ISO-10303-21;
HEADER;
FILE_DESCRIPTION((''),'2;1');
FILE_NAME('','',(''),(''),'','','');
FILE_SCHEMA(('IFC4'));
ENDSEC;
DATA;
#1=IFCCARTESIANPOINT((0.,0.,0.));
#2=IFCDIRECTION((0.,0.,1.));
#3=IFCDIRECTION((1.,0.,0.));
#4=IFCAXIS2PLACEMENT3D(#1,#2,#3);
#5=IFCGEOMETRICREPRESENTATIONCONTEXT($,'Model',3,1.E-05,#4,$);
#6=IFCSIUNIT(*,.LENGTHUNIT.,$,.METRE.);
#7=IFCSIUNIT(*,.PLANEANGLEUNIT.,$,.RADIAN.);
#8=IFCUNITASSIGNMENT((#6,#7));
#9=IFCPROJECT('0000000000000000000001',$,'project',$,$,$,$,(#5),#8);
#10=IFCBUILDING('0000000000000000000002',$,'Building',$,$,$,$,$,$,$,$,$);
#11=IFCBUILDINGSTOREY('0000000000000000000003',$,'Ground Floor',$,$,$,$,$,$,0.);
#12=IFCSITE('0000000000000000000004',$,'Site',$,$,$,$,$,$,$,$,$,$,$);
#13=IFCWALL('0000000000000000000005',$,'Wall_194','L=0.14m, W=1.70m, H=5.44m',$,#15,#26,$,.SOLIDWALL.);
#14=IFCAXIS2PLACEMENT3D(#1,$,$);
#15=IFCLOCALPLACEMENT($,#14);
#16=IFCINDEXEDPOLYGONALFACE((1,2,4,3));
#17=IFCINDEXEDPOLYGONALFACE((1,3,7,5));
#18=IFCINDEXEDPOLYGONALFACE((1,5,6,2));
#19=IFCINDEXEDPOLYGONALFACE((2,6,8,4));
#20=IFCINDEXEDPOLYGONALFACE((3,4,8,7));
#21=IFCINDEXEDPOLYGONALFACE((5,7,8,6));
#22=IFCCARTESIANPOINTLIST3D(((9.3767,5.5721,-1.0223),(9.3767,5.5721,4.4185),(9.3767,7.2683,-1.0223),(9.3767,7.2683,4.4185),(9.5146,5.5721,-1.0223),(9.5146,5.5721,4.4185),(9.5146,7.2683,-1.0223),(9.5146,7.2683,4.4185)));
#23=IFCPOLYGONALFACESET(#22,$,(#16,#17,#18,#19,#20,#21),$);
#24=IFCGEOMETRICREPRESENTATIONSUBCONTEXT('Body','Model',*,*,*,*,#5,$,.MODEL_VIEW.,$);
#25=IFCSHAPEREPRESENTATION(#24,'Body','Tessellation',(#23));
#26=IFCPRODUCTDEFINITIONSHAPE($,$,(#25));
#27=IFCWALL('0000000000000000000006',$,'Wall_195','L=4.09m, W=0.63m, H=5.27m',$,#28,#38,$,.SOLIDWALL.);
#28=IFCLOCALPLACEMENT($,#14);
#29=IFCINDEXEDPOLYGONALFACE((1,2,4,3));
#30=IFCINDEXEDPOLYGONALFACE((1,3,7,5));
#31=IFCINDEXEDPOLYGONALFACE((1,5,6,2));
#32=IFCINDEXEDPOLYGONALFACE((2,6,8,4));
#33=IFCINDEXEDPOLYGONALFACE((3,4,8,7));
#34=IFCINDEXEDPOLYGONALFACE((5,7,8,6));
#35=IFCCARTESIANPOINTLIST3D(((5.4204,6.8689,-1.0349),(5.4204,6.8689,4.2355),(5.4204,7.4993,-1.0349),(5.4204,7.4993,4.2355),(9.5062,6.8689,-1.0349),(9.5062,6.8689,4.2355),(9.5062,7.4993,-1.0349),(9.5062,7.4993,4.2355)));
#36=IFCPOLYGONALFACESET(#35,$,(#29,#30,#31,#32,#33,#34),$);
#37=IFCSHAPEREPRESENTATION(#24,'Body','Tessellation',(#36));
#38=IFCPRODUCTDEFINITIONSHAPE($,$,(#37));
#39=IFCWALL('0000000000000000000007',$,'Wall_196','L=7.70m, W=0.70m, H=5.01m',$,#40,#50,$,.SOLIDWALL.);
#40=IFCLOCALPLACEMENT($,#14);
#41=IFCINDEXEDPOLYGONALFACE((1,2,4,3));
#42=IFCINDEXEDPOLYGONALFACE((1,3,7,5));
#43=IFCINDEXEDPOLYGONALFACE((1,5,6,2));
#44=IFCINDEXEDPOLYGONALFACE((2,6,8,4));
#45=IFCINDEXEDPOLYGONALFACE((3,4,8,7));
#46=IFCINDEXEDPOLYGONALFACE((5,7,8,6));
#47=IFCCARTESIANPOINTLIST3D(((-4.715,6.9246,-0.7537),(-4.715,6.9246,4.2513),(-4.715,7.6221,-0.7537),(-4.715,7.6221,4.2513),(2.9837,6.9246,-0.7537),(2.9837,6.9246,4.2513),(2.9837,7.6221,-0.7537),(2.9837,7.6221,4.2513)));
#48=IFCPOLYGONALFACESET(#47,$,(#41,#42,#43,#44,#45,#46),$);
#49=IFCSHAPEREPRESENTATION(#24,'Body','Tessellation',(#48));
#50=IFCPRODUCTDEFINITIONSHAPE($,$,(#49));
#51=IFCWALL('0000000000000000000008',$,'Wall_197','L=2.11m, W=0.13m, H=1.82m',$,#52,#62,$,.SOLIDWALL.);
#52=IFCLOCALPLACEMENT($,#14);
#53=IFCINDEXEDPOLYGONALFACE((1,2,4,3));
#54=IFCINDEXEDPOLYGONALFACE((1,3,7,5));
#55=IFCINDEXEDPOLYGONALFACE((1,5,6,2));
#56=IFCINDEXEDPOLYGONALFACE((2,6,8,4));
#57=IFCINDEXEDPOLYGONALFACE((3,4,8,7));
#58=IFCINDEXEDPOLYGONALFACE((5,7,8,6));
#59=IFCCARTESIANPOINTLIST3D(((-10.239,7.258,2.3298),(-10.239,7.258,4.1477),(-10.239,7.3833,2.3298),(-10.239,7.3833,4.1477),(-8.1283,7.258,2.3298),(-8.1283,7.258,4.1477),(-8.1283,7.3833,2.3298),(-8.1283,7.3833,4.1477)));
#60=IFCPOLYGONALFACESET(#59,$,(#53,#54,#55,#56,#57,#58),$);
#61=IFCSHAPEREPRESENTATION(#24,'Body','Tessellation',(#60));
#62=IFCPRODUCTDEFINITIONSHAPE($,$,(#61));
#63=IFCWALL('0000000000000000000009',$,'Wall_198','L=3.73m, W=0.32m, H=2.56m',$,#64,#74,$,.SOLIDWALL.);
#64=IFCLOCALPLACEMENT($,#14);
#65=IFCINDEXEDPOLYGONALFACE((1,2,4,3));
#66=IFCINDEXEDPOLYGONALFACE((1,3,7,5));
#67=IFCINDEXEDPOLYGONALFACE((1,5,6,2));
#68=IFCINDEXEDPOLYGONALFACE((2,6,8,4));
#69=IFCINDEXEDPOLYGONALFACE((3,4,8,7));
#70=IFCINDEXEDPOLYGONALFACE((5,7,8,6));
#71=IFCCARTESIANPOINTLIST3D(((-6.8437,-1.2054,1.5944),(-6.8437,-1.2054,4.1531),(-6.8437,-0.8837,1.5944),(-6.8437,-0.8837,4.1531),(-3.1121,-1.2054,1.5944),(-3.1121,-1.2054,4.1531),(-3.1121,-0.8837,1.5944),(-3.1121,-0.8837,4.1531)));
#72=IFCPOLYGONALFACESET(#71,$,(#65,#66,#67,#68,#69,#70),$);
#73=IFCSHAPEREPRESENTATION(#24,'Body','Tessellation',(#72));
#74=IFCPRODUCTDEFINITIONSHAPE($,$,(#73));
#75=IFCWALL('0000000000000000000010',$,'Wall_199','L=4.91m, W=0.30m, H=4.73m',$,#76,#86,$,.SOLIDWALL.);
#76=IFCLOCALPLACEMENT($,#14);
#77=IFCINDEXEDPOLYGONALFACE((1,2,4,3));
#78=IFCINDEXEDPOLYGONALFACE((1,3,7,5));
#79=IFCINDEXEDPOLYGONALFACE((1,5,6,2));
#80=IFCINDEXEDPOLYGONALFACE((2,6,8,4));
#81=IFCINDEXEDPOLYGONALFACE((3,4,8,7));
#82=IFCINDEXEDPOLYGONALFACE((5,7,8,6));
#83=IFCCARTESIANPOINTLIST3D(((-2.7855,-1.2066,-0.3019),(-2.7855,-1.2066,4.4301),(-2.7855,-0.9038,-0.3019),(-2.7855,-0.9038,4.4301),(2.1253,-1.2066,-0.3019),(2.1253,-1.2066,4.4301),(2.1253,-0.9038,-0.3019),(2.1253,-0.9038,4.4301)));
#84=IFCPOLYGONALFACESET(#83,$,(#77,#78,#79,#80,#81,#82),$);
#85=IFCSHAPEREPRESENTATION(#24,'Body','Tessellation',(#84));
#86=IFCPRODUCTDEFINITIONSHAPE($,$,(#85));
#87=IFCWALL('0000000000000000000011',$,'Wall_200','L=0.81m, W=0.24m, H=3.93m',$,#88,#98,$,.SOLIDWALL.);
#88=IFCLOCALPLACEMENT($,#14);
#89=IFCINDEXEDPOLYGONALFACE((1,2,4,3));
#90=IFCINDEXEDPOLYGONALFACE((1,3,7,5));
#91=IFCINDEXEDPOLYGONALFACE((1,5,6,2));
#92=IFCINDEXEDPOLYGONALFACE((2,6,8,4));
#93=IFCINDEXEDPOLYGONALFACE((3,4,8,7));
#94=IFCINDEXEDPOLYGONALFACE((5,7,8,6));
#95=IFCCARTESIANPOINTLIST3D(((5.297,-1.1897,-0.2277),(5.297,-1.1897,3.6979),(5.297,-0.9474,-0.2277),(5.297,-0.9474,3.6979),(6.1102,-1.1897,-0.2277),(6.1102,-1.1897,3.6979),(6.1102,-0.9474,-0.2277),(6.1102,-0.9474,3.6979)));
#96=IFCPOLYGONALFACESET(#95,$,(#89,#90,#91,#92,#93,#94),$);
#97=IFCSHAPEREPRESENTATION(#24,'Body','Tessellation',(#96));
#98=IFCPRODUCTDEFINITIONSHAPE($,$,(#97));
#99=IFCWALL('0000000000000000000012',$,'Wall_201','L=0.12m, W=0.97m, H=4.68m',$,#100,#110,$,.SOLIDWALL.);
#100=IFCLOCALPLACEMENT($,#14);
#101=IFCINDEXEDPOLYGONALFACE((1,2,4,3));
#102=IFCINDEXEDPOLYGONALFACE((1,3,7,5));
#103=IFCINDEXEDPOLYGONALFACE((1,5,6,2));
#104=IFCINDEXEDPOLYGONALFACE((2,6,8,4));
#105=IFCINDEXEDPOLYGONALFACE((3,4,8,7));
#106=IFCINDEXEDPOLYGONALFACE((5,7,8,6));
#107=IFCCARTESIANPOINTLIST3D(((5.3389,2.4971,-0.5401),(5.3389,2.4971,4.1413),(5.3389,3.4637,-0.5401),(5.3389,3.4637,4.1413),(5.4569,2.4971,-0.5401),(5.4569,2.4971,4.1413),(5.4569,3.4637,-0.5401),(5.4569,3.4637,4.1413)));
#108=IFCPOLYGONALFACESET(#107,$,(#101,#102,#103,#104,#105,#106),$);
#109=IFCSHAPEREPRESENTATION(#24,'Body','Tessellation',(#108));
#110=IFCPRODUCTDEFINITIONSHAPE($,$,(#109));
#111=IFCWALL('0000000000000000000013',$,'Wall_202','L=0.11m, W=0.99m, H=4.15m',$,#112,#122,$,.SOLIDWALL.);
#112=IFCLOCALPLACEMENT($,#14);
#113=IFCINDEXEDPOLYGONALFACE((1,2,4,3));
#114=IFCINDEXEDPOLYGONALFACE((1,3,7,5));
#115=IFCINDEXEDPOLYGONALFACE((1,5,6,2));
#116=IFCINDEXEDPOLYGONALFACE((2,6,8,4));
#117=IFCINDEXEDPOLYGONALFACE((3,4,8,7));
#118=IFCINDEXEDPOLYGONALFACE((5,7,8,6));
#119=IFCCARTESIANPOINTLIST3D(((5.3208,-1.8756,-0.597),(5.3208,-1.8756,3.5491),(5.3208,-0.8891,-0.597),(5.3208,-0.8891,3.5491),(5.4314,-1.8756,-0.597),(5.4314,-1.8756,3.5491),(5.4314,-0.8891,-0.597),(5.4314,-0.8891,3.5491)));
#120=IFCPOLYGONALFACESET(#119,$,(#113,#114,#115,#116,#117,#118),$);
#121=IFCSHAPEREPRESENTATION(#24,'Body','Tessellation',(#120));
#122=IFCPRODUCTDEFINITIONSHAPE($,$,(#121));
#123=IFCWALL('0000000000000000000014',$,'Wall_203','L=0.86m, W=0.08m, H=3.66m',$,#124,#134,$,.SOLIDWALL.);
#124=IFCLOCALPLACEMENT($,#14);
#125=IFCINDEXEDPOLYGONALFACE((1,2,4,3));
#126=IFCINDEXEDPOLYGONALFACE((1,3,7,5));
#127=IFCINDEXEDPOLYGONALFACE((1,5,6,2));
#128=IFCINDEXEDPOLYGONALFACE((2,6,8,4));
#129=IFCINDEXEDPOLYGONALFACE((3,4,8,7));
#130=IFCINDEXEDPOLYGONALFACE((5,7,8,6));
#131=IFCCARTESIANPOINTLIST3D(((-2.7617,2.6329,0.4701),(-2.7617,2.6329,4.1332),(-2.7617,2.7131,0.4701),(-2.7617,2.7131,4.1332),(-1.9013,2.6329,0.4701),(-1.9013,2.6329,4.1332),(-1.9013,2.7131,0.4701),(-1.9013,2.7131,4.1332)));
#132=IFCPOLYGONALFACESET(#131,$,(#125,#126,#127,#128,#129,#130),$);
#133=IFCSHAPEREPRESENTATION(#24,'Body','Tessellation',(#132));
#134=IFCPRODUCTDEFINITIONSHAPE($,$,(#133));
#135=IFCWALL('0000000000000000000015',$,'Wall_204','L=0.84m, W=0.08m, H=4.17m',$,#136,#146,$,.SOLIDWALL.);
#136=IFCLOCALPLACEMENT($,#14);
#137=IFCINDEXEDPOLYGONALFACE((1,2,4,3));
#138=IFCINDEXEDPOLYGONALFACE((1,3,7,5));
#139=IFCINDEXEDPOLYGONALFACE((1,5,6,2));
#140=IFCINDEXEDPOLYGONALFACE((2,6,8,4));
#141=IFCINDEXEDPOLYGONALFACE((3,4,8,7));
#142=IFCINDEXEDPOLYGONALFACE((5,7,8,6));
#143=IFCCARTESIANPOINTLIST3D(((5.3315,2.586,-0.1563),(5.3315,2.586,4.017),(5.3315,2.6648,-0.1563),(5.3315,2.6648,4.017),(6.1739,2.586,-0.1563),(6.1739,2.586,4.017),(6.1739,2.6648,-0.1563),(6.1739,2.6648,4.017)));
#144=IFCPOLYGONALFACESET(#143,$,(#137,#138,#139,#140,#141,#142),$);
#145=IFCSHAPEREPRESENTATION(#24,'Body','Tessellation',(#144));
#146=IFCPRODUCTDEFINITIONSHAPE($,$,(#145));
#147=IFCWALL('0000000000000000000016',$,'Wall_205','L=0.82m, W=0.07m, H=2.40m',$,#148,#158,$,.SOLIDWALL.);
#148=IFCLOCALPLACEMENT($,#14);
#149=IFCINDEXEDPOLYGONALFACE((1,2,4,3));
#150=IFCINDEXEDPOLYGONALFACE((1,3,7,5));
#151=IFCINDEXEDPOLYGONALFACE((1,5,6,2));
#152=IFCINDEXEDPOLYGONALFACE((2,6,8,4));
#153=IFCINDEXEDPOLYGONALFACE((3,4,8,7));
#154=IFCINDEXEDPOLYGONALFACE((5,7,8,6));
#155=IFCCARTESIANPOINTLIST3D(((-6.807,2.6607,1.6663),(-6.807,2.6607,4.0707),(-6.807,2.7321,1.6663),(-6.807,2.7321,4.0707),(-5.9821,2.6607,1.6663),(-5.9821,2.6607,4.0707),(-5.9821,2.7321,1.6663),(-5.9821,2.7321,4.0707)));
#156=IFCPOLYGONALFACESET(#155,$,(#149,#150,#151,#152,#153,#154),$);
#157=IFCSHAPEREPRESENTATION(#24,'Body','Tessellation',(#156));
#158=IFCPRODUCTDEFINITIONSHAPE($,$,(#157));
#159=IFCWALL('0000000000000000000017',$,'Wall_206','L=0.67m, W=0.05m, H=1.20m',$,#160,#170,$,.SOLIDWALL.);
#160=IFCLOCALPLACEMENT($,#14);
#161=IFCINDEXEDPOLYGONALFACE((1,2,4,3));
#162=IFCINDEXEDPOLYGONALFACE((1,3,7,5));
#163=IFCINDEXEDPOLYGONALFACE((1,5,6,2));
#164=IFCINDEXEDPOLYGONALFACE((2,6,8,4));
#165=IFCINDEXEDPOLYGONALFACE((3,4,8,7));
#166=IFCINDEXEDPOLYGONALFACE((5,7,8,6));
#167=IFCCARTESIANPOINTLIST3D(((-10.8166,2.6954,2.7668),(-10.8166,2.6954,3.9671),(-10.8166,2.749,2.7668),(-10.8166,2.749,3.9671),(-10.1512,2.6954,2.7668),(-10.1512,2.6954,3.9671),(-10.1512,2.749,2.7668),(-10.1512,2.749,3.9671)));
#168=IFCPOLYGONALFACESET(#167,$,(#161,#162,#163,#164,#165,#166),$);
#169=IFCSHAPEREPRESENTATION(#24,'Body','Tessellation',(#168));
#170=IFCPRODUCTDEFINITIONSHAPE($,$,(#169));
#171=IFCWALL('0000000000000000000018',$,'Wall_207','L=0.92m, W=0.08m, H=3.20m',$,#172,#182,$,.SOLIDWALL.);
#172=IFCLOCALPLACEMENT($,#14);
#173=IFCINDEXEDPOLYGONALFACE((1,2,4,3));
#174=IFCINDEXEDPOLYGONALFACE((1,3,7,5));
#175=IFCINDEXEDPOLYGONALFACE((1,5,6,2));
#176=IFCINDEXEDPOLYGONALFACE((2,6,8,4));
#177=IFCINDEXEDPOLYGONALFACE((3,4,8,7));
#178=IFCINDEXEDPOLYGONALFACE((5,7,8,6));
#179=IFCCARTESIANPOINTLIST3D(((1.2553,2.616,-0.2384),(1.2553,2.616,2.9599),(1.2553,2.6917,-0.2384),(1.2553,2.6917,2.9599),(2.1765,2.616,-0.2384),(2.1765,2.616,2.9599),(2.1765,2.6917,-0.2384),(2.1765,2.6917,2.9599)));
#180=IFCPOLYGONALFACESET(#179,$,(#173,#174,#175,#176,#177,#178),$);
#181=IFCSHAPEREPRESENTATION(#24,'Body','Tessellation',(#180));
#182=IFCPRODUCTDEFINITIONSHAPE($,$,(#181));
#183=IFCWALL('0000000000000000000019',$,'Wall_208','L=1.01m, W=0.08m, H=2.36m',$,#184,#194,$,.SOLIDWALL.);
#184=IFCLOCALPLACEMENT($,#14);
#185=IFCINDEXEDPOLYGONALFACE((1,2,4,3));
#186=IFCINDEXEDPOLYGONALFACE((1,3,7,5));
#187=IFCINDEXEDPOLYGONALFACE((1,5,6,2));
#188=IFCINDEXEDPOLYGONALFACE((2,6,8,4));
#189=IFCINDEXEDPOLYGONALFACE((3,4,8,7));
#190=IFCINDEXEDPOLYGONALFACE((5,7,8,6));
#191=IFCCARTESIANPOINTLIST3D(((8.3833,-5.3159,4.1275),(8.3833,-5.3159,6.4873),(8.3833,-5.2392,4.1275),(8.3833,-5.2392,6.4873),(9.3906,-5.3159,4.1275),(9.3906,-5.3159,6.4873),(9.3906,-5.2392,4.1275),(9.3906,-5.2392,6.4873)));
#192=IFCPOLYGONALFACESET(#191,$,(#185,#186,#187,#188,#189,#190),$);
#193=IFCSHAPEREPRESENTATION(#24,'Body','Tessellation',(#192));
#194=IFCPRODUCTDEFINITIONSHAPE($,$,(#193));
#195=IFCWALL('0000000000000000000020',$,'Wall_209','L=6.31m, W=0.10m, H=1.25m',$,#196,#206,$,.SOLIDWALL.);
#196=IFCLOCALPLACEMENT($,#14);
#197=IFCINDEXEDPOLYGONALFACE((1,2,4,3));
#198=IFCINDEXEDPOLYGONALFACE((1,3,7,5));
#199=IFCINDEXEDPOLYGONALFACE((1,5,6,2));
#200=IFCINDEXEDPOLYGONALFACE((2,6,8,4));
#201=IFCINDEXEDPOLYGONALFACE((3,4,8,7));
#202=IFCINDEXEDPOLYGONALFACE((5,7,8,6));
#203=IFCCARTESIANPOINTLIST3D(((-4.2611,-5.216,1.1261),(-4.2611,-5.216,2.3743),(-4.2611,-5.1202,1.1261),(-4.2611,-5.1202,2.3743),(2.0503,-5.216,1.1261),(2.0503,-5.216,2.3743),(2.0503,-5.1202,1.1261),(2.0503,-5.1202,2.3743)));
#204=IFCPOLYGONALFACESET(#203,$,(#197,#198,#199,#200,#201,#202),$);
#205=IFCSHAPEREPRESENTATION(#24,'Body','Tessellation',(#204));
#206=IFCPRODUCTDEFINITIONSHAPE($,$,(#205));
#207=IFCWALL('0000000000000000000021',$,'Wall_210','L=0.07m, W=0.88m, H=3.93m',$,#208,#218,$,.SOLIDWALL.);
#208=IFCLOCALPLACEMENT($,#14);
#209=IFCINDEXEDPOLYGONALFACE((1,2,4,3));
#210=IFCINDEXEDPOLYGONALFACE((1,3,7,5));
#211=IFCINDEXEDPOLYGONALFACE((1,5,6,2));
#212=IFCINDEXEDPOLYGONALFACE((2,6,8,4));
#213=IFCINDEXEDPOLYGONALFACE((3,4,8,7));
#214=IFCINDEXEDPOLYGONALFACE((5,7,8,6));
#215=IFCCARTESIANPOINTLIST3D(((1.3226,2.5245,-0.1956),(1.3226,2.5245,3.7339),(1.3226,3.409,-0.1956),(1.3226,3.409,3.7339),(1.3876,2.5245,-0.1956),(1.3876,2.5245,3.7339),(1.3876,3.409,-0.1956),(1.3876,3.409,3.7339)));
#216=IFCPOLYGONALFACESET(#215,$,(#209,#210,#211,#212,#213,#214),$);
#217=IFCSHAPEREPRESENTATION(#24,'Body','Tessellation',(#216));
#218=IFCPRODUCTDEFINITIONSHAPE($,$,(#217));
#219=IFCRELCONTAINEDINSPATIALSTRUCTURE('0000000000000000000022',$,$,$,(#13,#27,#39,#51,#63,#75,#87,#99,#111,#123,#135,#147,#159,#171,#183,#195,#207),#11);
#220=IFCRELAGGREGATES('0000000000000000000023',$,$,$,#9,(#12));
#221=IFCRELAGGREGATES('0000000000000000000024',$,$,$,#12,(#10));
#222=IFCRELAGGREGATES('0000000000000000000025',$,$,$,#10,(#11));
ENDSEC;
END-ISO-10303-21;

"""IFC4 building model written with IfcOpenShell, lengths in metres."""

from ifc_helpers import new_model, si_unit, frame, origin_with_axes, origin_2d, context, subcontext, project, spatial, rectangle, extrude, element, save


model = new_model("IFC4")

# Units and contexts
model_context = context("Model", 3, precision=1e-05, world=origin_with_axes())
body_context = subcontext(model_context, "Body", "Model", "MODEL_VIEW")
ifc_project = project(units=[si_unit("LENGTHUNIT", "METRE"), si_unit("PLANEANGLEUNIT", "RADIAN")], contexts=[model_context])

# Site, building, storey
site = spatial("IfcSite", under=ifc_project, Name="Site")
building = spatial("IfcBuilding", under=site, Name="Building")
storey = spatial("IfcBuildingStorey", under=building, Name="Ground Floor", Elevation=0.0)

# Walls
element("IfcWall", 1, inside=storey, Name="Wall_194", Description="L=0.14m, W=1.70m, H=5.44m", PredefinedType="SOLIDWALL", context=body_context, shape_type="SweptSolid", body=[
    extrude(rectangle(XDim=0.1379, YDim=1.6961, at=origin_2d()), frame((9.4457, 6.4202, -1.0223), z_axis=(0.0, 0.0, 1.0), x_axis=(1.0, 0.0, 0.0)), (0.0, 0.0, 1.0), 5.4408),
])
element("IfcWall", 2, inside=storey, Name="Wall_195", Description="L=4.09m, W=0.63m, H=5.27m", PredefinedType="SOLIDWALL", context=body_context, shape_type="SweptSolid", body=[
    extrude(rectangle(XDim=4.0858, YDim=0.6304, at=origin_2d()), frame((7.4633, 7.1841, -1.0349), z_axis=(0.0, 0.0, 1.0), x_axis=(1.0, 0.0, 0.0)), (0.0, 0.0, 1.0), 5.2704),
])
element("IfcWall", 3, inside=storey, Name="Wall_196", Description="L=7.70m, W=0.70m, H=5.01m", PredefinedType="SOLIDWALL", context=body_context, shape_type="SweptSolid", body=[
    extrude(rectangle(XDim=7.6987, YDim=0.6975, at=origin_2d()), frame((-0.8657, 7.2734, -0.7537), z_axis=(0.0, 0.0, 1.0), x_axis=(1.0, 0.0, 0.0)), (0.0, 0.0, 1.0), 5.005),
])
element("IfcWall", 4, inside=storey, Name="Wall_197", Description="L=2.11m, W=0.13m, H=1.82m", PredefinedType="SOLIDWALL", context=body_context, shape_type="SweptSolid", body=[
    extrude(rectangle(XDim=2.1107, YDim=0.1253, at=origin_2d()), frame((-9.1836, 7.3206, 2.3298), z_axis=(0.0, 0.0, 1.0), x_axis=(1.0, 0.0, 0.0)), (0.0, 0.0, 1.0), 1.8179),
])
element("IfcWall", 5, inside=storey, Name="Wall_198", Description="L=3.73m, W=0.32m, H=2.56m", PredefinedType="SOLIDWALL", context=body_context, shape_type="SweptSolid", body=[
    extrude(rectangle(XDim=3.7316, YDim=0.3217, at=origin_2d()), frame((-4.9779, -1.0446, 1.5944), z_axis=(0.0, 0.0, 1.0), x_axis=(1.0, 0.0, 0.0)), (0.0, 0.0, 1.0), 2.5587),
])
element("IfcWall", 6, inside=storey, Name="Wall_199", Description="L=4.91m, W=0.30m, H=4.73m", PredefinedType="SOLIDWALL", context=body_context, shape_type="SweptSolid", body=[
    extrude(rectangle(XDim=4.9108, YDim=0.3027, at=origin_2d()), frame((-0.3301, -1.0552, -0.3019), z_axis=(0.0, 0.0, 1.0), x_axis=(1.0, 0.0, 0.0)), (0.0, 0.0, 1.0), 4.732),
])
element("IfcWall", 7, inside=storey, Name="Wall_200", Description="L=0.81m, W=0.24m, H=3.93m", PredefinedType="SOLIDWALL", context=body_context, shape_type="SweptSolid", body=[
    extrude(rectangle(XDim=0.8132, YDim=0.2422, at=origin_2d()), frame((5.7036, -1.0686, -0.2277), z_axis=(0.0, 0.0, 1.0), x_axis=(1.0, 0.0, 0.0)), (0.0, 0.0, 1.0), 3.9256),
])
element("IfcWall", 8, inside=storey, Name="Wall_201", Description="L=0.12m, W=0.97m, H=4.68m", PredefinedType="SOLIDWALL", context=body_context, shape_type="SweptSolid", body=[
    extrude(rectangle(XDim=0.1179, YDim=0.9666, at=origin_2d()), frame((5.3979, 2.9804, -0.5401), z_axis=(0.0, 0.0, 1.0), x_axis=(1.0, 0.0, 0.0)), (0.0, 0.0, 1.0), 4.6814),
])
element("IfcWall", 9, inside=storey, Name="Wall_202", Description="L=0.11m, W=0.99m, H=4.15m", PredefinedType="SOLIDWALL", context=body_context, shape_type="SweptSolid", body=[
    extrude(rectangle(XDim=0.1106, YDim=0.9865, at=origin_2d()), frame((5.3761, -1.3823, -0.597), z_axis=(0.0, 0.0, 1.0), x_axis=(1.0, 0.0, 0.0)), (0.0, 0.0, 1.0), 4.1461),
])
element("IfcWall", 10, inside=storey, Name="Wall_203", Description="L=0.86m, W=0.08m, H=3.66m", PredefinedType="SOLIDWALL", context=body_context, shape_type="SweptSolid", body=[
    extrude(rectangle(XDim=0.8604, YDim=0.0802, at=origin_2d()), frame((-2.3315, 2.673, 0.4701), z_axis=(0.0, 0.0, 1.0), x_axis=(1.0, 0.0, 0.0)), (0.0, 0.0, 1.0), 3.6632),
])
element("IfcWall", 11, inside=storey, Name="Wall_204", Description="L=0.84m, W=0.08m, H=4.17m", PredefinedType="SOLIDWALL", context=body_context, shape_type="SweptSolid", body=[
    extrude(rectangle(XDim=0.8424, YDim=0.0789, at=origin_2d()), frame((5.7527, 2.6254, -0.1563), z_axis=(0.0, 0.0, 1.0), x_axis=(1.0, 0.0, 0.0)), (0.0, 0.0, 1.0), 4.1733),
])
element("IfcWall", 12, inside=storey, Name="Wall_205", Description="L=0.82m, W=0.07m, H=2.40m", PredefinedType="SOLIDWALL", context=body_context, shape_type="SweptSolid", body=[
    extrude(rectangle(XDim=0.8249, YDim=0.0715, at=origin_2d()), frame((-6.3946, 2.6964, 1.6663), z_axis=(0.0, 0.0, 1.0), x_axis=(1.0, 0.0, 0.0)), (0.0, 0.0, 1.0), 2.4045),
])
element("IfcWall", 13, inside=storey, Name="Wall_206", Description="L=0.67m, W=0.05m, H=1.20m", PredefinedType="SOLIDWALL", context=body_context, shape_type="SweptSolid", body=[
    extrude(rectangle(XDim=0.6654, YDim=0.0535, at=origin_2d()), frame((-10.4839, 2.7222, 2.7668), z_axis=(0.0, 0.0, 1.0), x_axis=(1.0, 0.0, 0.0)), (0.0, 0.0, 1.0), 1.2003),
])
element("IfcWall", 14, inside=storey, Name="Wall_207", Description="L=0.92m, W=0.08m, H=3.20m", PredefinedType="SOLIDWALL", context=body_context, shape_type="SweptSolid", body=[
    extrude(rectangle(XDim=0.9212, YDim=0.0757, at=origin_2d()), frame((1.7159, 2.6539, -0.2384), z_axis=(0.0, 0.0, 1.0), x_axis=(1.0, 0.0, 0.0)), (0.0, 0.0, 1.0), 3.1983),
])
element("IfcWall", 15, inside=storey, Name="Wall_208", Description="L=1.01m, W=0.08m, H=2.36m", PredefinedType="SOLIDWALL", context=body_context, shape_type="SweptSolid", body=[
    extrude(rectangle(XDim=1.0073, YDim=0.0766, at=origin_2d()), frame((8.8869, -5.2776, 4.1275), z_axis=(0.0, 0.0, 1.0), x_axis=(1.0, 0.0, 0.0)), (0.0, 0.0, 1.0), 2.3598),
])
element("IfcWall", 16, inside=storey, Name="Wall_209", Description="L=6.31m, W=0.10m, H=1.25m", PredefinedType="SOLIDWALL", context=body_context, shape_type="SweptSolid", body=[
    extrude(rectangle(XDim=6.3114, YDim=0.0959, at=origin_2d()), frame((-1.1054, -5.1681, 1.1261), z_axis=(0.0, 0.0, 1.0), x_axis=(1.0, 0.0, 0.0)), (0.0, 0.0, 1.0), 1.2482),
])
element("IfcWall", 17, inside=storey, Name="Wall_210", Description="L=0.07m, W=0.88m, H=3.93m", PredefinedType="SOLIDWALL", context=body_context, shape_type="SweptSolid", body=[
    extrude(rectangle(XDim=0.065, YDim=0.8844, at=origin_2d()), frame((1.3551, 2.9667, -0.1956), z_axis=(0.0, 0.0, 1.0), x_axis=(1.0, 0.0, 0.0)), (0.0, 0.0, 1.0), 3.9294),
])

save(model, "model.ifc")
